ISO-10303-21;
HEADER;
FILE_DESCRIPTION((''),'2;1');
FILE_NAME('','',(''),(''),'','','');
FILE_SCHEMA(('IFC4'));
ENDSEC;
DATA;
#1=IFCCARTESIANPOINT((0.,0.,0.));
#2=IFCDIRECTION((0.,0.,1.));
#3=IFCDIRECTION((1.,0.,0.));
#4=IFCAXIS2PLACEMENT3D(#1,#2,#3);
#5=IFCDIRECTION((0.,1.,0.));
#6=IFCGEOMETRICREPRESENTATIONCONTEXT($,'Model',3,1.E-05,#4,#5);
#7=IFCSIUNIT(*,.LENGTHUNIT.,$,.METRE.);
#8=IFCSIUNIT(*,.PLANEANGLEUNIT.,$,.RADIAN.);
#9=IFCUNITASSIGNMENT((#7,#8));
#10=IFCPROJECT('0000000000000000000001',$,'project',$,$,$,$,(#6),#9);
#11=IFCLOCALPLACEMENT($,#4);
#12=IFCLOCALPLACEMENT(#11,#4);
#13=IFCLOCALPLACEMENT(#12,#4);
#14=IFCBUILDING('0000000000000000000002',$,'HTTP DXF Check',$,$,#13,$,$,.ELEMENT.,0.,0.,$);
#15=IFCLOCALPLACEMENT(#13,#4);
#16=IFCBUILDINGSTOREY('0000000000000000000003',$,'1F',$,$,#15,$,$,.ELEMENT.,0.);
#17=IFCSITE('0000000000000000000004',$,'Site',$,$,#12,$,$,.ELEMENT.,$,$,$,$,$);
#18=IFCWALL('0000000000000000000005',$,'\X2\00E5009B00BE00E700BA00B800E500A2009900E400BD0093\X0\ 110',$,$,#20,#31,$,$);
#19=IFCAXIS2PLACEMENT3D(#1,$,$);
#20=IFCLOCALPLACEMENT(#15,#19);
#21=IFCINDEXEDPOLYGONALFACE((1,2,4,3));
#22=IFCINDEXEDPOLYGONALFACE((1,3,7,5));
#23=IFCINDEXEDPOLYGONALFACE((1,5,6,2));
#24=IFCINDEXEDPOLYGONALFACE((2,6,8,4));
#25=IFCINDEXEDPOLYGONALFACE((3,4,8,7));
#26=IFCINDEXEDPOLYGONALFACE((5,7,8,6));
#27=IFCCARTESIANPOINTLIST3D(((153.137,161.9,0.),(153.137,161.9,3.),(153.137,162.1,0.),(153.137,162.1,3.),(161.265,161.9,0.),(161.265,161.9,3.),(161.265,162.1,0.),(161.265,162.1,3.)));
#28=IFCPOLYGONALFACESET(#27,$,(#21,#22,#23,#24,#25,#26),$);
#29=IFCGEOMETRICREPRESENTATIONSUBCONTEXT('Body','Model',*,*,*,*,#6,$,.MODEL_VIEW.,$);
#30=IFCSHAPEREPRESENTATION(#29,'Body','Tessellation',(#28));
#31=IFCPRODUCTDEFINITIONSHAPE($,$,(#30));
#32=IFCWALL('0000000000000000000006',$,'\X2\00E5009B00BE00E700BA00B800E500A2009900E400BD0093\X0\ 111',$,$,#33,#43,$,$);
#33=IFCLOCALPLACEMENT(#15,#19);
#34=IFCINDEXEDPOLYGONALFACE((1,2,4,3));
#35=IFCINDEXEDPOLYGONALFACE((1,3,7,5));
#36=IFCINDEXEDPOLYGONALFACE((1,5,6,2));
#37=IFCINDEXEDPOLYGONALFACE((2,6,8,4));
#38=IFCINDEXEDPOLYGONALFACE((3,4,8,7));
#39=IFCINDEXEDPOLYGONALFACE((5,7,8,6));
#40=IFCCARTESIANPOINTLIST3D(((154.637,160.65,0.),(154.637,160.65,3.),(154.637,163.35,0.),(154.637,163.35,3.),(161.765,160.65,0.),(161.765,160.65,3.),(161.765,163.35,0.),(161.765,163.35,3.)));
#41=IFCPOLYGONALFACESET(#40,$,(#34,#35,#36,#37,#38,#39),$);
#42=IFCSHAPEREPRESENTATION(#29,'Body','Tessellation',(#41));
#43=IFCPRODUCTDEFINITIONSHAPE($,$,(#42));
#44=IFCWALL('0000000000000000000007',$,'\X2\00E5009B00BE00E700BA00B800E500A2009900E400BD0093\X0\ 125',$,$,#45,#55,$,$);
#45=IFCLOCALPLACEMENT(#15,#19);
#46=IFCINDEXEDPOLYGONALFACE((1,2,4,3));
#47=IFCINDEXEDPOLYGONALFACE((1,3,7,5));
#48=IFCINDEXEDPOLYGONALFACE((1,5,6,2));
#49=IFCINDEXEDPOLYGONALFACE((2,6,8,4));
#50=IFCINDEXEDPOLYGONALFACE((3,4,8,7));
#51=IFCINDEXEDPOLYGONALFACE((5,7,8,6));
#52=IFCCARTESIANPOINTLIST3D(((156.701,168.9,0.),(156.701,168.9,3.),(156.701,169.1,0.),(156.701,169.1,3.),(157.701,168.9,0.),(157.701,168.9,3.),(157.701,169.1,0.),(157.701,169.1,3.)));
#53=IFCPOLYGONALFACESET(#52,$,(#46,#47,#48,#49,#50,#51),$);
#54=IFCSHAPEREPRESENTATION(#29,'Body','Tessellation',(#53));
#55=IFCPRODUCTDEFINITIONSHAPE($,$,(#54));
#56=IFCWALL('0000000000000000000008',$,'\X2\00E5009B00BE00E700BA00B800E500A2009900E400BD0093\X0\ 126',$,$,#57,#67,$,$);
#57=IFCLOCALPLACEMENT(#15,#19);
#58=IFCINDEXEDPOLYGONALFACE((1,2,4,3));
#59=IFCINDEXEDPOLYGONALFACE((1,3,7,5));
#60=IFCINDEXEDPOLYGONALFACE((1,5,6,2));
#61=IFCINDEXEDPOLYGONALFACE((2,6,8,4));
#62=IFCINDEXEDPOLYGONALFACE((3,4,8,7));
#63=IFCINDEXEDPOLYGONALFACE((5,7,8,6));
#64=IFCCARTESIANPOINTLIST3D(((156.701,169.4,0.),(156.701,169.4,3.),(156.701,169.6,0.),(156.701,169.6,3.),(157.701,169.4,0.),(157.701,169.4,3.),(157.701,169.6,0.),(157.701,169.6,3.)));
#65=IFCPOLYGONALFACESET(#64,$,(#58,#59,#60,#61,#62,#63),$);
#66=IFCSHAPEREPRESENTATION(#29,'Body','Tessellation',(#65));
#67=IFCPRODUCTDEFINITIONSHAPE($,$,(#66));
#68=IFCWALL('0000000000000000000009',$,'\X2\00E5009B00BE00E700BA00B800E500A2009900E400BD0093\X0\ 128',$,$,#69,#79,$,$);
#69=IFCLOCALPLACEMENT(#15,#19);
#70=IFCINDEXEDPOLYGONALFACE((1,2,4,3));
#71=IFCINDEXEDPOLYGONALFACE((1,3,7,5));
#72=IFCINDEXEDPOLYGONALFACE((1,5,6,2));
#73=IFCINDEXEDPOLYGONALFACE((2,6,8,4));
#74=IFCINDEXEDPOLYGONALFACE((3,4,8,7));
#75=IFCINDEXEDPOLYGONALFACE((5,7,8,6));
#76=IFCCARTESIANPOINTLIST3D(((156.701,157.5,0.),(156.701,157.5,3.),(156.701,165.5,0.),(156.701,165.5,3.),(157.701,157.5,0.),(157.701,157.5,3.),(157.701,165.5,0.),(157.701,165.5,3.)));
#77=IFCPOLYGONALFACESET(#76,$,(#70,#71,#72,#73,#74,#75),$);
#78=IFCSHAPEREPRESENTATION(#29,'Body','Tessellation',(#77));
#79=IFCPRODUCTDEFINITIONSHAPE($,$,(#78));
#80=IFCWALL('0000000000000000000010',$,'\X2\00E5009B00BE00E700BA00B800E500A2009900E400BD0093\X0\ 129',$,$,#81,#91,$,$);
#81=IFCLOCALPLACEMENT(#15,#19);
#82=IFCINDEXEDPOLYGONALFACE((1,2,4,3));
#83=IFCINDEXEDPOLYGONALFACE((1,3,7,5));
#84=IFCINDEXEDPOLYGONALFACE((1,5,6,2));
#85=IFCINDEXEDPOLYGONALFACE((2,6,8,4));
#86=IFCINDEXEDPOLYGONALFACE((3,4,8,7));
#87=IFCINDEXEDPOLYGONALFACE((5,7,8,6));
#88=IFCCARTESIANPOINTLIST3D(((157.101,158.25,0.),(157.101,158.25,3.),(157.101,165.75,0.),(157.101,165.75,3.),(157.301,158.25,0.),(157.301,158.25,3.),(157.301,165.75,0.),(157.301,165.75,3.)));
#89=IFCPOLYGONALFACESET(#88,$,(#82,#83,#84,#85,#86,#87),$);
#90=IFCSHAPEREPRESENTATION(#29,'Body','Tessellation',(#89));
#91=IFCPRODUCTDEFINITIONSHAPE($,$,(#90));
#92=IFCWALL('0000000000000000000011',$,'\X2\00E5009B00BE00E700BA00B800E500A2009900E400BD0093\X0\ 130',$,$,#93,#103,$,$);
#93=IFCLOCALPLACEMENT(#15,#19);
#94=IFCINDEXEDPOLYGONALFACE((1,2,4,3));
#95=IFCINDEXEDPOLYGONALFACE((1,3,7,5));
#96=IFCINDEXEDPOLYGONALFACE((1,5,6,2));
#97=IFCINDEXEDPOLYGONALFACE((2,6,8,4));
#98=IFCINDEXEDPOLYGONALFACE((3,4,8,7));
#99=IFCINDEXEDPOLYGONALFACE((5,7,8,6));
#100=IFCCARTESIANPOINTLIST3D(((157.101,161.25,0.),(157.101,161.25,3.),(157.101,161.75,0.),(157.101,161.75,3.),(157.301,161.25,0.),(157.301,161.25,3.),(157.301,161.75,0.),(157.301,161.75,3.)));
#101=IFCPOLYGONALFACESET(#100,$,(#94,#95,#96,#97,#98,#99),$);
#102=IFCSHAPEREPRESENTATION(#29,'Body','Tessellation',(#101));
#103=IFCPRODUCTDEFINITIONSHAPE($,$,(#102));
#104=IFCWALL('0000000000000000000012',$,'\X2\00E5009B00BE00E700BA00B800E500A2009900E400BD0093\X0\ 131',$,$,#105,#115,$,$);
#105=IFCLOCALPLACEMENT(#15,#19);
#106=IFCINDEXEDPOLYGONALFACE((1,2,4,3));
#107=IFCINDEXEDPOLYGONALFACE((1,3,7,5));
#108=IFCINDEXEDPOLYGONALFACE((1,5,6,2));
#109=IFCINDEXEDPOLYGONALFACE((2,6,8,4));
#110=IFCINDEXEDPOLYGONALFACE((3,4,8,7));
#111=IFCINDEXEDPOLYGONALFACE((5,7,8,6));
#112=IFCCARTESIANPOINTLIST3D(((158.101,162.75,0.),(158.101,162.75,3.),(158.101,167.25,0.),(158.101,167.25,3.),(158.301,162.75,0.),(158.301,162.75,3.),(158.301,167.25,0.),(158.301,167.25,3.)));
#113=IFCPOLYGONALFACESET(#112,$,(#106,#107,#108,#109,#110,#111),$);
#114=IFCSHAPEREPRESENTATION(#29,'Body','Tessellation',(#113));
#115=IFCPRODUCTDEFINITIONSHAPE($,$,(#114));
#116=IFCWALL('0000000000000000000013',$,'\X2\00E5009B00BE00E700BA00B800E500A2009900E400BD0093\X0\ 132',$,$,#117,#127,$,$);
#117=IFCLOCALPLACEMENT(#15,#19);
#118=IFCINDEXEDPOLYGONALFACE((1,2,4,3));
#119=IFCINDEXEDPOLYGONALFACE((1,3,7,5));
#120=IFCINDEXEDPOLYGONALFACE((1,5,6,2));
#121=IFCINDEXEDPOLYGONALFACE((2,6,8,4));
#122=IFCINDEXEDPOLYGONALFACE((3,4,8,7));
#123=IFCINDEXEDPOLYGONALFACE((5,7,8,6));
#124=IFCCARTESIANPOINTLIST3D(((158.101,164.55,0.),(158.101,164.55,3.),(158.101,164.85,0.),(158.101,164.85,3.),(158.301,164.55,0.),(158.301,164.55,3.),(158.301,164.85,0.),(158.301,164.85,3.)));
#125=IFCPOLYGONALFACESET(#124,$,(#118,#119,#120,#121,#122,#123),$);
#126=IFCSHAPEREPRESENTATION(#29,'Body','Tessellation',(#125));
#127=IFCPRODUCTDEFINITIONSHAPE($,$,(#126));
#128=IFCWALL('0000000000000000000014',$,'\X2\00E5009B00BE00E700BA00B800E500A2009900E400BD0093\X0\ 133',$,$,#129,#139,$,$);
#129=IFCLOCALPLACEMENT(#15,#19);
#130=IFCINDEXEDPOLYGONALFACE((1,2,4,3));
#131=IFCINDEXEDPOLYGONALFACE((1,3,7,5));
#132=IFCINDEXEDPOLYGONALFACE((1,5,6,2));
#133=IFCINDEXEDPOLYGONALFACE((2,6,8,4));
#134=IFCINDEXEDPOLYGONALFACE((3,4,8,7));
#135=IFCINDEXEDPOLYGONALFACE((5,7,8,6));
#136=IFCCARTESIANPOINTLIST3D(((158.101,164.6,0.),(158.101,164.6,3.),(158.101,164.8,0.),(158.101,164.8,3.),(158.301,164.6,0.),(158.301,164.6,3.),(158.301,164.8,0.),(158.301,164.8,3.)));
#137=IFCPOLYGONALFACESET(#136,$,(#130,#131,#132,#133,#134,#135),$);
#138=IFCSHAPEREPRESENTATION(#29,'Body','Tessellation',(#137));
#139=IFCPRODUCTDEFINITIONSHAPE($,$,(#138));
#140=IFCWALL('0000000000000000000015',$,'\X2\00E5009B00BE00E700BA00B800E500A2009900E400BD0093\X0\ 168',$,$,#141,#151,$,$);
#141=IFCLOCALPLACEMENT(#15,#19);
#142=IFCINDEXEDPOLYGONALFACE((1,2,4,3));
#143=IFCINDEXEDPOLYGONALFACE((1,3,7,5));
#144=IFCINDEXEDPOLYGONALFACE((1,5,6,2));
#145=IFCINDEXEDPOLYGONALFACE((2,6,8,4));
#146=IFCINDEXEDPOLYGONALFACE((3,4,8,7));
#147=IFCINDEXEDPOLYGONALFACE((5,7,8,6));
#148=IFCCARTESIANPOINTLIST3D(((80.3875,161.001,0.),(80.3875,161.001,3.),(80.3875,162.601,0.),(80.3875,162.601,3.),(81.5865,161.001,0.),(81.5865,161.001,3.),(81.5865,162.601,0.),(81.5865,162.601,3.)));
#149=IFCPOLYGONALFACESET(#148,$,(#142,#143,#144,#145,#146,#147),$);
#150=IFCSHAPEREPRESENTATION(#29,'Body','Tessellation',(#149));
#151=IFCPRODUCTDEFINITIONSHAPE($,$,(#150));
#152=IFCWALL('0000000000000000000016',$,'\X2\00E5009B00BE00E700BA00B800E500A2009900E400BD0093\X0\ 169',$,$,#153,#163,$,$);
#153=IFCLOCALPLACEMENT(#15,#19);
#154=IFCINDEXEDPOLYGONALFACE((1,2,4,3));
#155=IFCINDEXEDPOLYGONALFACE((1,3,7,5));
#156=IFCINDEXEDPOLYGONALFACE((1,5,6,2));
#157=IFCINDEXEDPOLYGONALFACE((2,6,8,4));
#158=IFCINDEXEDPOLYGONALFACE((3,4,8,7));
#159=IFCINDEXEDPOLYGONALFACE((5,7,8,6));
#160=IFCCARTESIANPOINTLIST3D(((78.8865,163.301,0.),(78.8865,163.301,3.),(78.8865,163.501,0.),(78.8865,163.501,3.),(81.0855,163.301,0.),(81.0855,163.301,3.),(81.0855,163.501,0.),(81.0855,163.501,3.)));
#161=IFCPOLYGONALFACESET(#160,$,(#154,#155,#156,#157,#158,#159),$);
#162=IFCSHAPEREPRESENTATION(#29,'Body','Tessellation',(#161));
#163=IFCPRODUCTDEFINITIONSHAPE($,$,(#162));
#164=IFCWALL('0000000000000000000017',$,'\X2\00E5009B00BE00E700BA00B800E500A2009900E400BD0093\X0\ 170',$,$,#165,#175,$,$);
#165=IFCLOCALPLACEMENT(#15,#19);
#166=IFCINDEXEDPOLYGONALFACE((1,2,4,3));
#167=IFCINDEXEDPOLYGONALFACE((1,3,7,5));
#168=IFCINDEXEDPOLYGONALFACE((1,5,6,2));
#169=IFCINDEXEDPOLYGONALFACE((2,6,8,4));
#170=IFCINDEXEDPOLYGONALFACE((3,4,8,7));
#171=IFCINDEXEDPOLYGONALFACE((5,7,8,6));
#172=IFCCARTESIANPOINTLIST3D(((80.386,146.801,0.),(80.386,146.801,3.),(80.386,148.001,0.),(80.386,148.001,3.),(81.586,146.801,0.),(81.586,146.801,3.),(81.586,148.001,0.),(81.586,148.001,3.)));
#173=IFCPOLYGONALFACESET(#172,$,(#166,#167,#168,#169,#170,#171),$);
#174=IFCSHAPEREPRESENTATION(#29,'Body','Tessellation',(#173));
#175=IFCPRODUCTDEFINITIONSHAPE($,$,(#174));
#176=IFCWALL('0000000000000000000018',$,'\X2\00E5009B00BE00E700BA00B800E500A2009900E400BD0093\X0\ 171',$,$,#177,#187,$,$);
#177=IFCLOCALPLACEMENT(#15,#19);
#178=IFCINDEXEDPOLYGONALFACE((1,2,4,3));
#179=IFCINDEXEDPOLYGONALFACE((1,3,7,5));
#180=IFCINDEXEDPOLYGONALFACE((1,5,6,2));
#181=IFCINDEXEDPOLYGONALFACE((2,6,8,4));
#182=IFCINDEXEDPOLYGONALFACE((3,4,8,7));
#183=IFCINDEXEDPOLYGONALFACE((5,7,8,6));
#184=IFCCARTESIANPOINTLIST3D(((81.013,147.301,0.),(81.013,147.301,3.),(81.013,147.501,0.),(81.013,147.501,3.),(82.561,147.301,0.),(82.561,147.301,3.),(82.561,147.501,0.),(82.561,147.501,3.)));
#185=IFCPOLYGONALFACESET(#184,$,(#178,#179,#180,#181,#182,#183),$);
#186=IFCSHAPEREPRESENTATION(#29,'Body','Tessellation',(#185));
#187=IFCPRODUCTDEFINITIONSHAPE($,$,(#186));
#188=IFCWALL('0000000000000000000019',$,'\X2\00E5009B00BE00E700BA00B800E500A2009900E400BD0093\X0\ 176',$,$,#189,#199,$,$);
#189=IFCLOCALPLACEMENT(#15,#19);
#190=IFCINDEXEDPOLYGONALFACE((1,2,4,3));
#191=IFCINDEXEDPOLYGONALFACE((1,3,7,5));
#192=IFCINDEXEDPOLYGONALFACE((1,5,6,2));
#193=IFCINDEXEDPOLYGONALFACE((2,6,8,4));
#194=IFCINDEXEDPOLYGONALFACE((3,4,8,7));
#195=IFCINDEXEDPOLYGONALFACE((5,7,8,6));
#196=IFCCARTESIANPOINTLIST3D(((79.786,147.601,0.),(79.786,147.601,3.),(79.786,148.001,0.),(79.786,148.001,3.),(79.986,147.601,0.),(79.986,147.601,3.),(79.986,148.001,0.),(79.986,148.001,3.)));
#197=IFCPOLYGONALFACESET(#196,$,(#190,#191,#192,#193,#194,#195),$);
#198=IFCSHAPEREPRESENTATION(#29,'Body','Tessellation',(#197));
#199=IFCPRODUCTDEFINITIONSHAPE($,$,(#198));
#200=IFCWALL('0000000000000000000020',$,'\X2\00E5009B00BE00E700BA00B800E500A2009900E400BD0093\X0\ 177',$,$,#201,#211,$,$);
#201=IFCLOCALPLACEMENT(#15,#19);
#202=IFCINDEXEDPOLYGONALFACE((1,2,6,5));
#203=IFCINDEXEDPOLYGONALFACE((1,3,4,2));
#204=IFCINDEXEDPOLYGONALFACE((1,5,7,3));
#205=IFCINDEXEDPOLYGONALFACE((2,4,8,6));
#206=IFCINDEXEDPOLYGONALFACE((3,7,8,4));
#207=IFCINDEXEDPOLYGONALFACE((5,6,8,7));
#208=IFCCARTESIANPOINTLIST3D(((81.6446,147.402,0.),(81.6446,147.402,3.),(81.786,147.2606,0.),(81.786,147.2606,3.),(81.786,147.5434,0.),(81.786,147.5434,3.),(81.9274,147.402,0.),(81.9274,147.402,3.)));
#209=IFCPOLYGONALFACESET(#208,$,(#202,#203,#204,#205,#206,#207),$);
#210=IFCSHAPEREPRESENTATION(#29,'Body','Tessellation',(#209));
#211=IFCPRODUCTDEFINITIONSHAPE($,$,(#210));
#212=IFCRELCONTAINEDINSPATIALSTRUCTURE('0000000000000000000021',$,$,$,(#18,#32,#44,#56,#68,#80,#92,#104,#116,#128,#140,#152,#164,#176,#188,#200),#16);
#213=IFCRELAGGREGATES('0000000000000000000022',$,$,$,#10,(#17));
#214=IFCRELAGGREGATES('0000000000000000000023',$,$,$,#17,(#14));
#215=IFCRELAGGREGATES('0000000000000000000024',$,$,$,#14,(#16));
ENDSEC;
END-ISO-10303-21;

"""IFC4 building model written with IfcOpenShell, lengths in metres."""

from ifc_helpers import new_model, si_unit, direction, frame, frame_2d, origin_with_axes, place, context, subcontext, project, spatial, rectangle, extrude, element, save


model = new_model("IFC4")

# Units and contexts
model_context = context("Model", 3, precision=1e-05, world=origin_with_axes(), true_north=direction((0.0, 1.0, 0.0)))
body_context = subcontext(model_context, "Body", "Model", "MODEL_VIEW")
ifc_project = project(units=[si_unit("LENGTHUNIT", "METRE"), si_unit("PLANEANGLEUNIT", "RADIAN")], contexts=[model_context])

# Site, building, storey
placement = place(None, origin_with_axes())
site_placement = place(placement, origin_with_axes())
site = spatial("IfcSite", under=ifc_project, at=site_placement, Name="Site", CompositionType="ELEMENT")
building_placement = place(site_placement, origin_with_axes())
building = spatial("IfcBuilding", under=site, at=building_placement, Name="HTTP DXF Check", CompositionType="ELEMENT", ElevationOfRefHeight=0.0, ElevationOfTerrain=0.0)
storey_placement = place(building_placement, origin_with_axes())
storey = spatial("IfcBuildingStorey", under=building, at=storey_placement, Name="1F", CompositionType="ELEMENT", Elevation=0.0)

# Walls
wall_1_placement = place(storey_placement, frame((157.201, 162.0, 0.0), z_axis=(0.0, 0.0, 1.0), x_axis=(1.0, 0.0, 0.0)))
element("IfcWall", 1, at=wall_1_placement, inside=storey, Name="å\u009b¾çº¸å¢\u0099ä½\u0093 110", context=body_context, shape_type="SweptSolid", body=[
    extrude(rectangle(XDim=8.128, YDim=0.2, at=frame_2d((0.0, 0.0), x_axis=(1.0, 0.0, 0.0))), frame((0.0, 0.0, 0.0), z_axis=(0.0, 0.0, 1.0)), (0.0, 0.0, 1.0), 3.0),
])
wall_2_placement = place(storey_placement, frame((158.201, 162.0, 0.0), z_axis=(0.0, 0.0, 1.0), x_axis=(1.0, 0.0, 0.0)))
element("IfcWall", 2, at=wall_2_placement, inside=storey, Name="å\u009b¾çº¸å¢\u0099ä½\u0093 111", context=body_context, shape_type="SweptSolid", body=[
    extrude(rectangle(XDim=7.128, YDim=2.7, at=frame_2d((0.0, 0.0), x_axis=(1.0, 0.0, 0.0))), frame((0.0, 0.0, 0.0), z_axis=(0.0, 0.0, 1.0)), (0.0, 0.0, 1.0), 3.0),
])
for number, where, z_axis, x_axis, name in (
    (3, (157.201, 169.0, 0.0), (0.0, 0.0, 1.0), (1.0, 0.0, 0.0), "å\u009b¾çº¸å¢\u0099ä½\u0093 125"),
    (4, (157.201, 169.5, 0.0), (0.0, 0.0, 1.0), (1.0, 0.0, 0.0), "å\u009b¾çº¸å¢\u0099ä½\u0093 126"),
):
    element("IfcWall", number, at=place(storey_placement, frame(where, z_axis=z_axis, x_axis=x_axis)), inside=storey, Name=name, context=body_context, shape_type="SweptSolid", body=[
        extrude(rectangle(XDim=1.0, YDim=0.2, at=frame_2d((0.0, 0.0), x_axis=(1.0, 0.0, 0.0))), frame((0.0, 0.0, 0.0), z_axis=(0.0, 0.0, 1.0)), (0.0, 0.0, 1.0), 3.0),
    ])
wall_3_placement = place(storey_placement, frame((157.201, 161.5, 0.0), z_axis=(0.0, 0.0, 1.0), x_axis=(1.0, 0.0, 0.0)))
element("IfcWall", 5, at=wall_3_placement, inside=storey, Name="å\u009b¾çº¸å¢\u0099ä½\u0093 128", context=body_context, shape_type="SweptSolid", body=[
    extrude(rectangle(XDim=1.0, YDim=8.0, at=frame_2d((0.0, 0.0), x_axis=(1.0, 0.0, 0.0))), frame((0.0, 0.0, 0.0), z_axis=(0.0, 0.0, 1.0)), (0.0, 0.0, 1.0), 3.0),
])
wall_4_placement = place(storey_placement, frame((157.201, 162.0, 0.0), z_axis=(0.0, 0.0, 1.0), x_axis=(0.0, 1.0, 0.0)))
element("IfcWall", 6, at=wall_4_placement, inside=storey, Name="å\u009b¾çº¸å¢\u0099ä½\u0093 129", context=body_context, shape_type="SweptSolid", body=[
    extrude(rectangle(XDim=7.5, YDim=0.2, at=frame_2d((0.0, 0.0), x_axis=(1.0, 0.0, 0.0))), frame((0.0, 0.0, 0.0), z_axis=(0.0, 0.0, 1.0)), (0.0, 0.0, 1.0), 3.0),
])
wall_5_placement = place(storey_placement, frame((157.201, 161.5, 0.0), z_axis=(0.0, 0.0, 1.0), x_axis=(0.0, 1.0, 0.0)))
element("IfcWall", 7, at=wall_5_placement, inside=storey, Name="å\u009b¾çº¸å¢\u0099ä½\u0093 130", context=body_context, shape_type="SweptSolid", body=[
    extrude(rectangle(XDim=0.5, YDim=0.2, at=frame_2d((0.0, 0.0), x_axis=(1.0, 0.0, 0.0))), frame((0.0, 0.0, 0.0), z_axis=(0.0, 0.0, 1.0)), (0.0, 0.0, 1.0), 3.0),
])
wall_6_placement = place(storey_placement, frame((158.201, 165.0, 0.0), z_axis=(0.0, 0.0, 1.0), x_axis=(0.0, 1.0, 0.0)))
element("IfcWall", 8, at=wall_6_placement, inside=storey, Name="å\u009b¾çº¸å¢\u0099ä½\u0093 131", context=body_context, shape_type="SweptSolid", body=[
    extrude(rectangle(XDim=4.5, YDim=0.2, at=frame_2d((0.0, 0.0), x_axis=(1.0, 0.0, 0.0))), frame((0.0, 0.0, 0.0), z_axis=(0.0, 0.0, 1.0)), (0.0, 0.0, 1.0), 3.0),
])
wall_7_placement = place(storey_placement, frame((158.201, 164.7, 0.0), z_axis=(0.0, 0.0, 1.0), x_axis=(1.0, 0.0, 0.0)))
element("IfcWall", 9, at=wall_7_placement, inside=storey, Name="å\u009b¾çº¸å¢\u0099ä½\u0093 132", context=body_context, shape_type="SweptSolid", body=[
    extrude(rectangle(XDim=0.2, YDim=0.3, at=frame_2d((0.0, 0.0), x_axis=(1.0, 0.0, 0.0))), frame((0.0, 0.0, 0.0), z_axis=(0.0, 0.0, 1.0)), (0.0, 0.0, 1.0), 3.0),
])
wall_8_placement = place(storey_placement, frame((158.201, 164.7, 0.0), z_axis=(0.0, 0.0, 1.0), x_axis=(1.0, 0.0, 0.0)))
element("IfcWall", 10, at=wall_8_placement, inside=storey, Name="å\u009b¾çº¸å¢\u0099ä½\u0093 133", context=body_context, shape_type="SweptSolid", body=[
    extrude(rectangle(XDim=0.2, YDim=0.2, at=frame_2d((0.0, 0.0), x_axis=(1.0, 0.0, 0.0))), frame((0.0, 0.0, 0.0), z_axis=(0.0, 0.0, 1.0)), (0.0, 0.0, 1.0), 3.0),
])
wall_9_placement = place(storey_placement, frame((80.987, 161.801, 0.0), z_axis=(0.0, 0.0, 1.0), x_axis=(1.0, 0.0, 0.0)))
element("IfcWall", 11, at=wall_9_placement, inside=storey, Name="å\u009b¾çº¸å¢\u0099ä½\u0093 168", context=body_context, shape_type="SweptSolid", body=[
    extrude(rectangle(XDim=1.199, YDim=1.6, at=frame_2d((0.0, 0.0), x_axis=(1.0, 0.0, 0.0))), frame((0.0, 0.0, 0.0), z_axis=(0.0, 0.0, 1.0)), (0.0, 0.0, 1.0), 3.0),
])
wall_10_placement = place(storey_placement, frame((79.986, 163.401, 0.0), z_axis=(0.0, 0.0, 1.0), x_axis=(1.0, 0.0, 0.0)))
element("IfcWall", 12, at=wall_10_placement, inside=storey, Name="å\u009b¾çº¸å¢\u0099ä½\u0093 169", context=body_context, shape_type="SweptSolid", body=[
    extrude(rectangle(XDim=2.199, YDim=0.2, at=frame_2d((0.0, 0.0), x_axis=(1.0, 0.0, 0.0))), frame((0.0, 0.0, 0.0), z_axis=(0.0, 0.0, 1.0)), (0.0, 0.0, 1.0), 3.0),
])
wall_11_placement = place(storey_placement, frame((80.986, 147.401, 0.0), z_axis=(0.0, 0.0, 1.0), x_axis=(1.0, 0.0, 0.0)))
element("IfcWall", 13, at=wall_11_placement, inside=storey, Name="å\u009b¾çº¸å¢\u0099ä½\u0093 170", context=body_context, shape_type="SweptSolid", body=[
    extrude(rectangle(XDim=1.2, YDim=1.2, at=frame_2d((0.0, 0.0), x_axis=(1.0, 0.0, 0.0))), frame((0.0, 0.0, 0.0), z_axis=(0.0, 0.0, 1.0)), (0.0, 0.0, 1.0), 3.0),
])
wall_12_placement = place(storey_placement, frame((81.787, 147.401, 0.0), z_axis=(0.0, 0.0, 1.0), x_axis=(1.0, 0.0, 0.0)))
element("IfcWall", 14, at=wall_12_placement, inside=storey, Name="å\u009b¾çº¸å¢\u0099ä½\u0093 171", context=body_context, shape_type="SweptSolid", body=[
    extrude(rectangle(XDim=1.548, YDim=0.2, at=frame_2d((0.0, 0.0), x_axis=(1.0, 0.0, 0.0))), frame((0.0, 0.0, 0.0), z_axis=(0.0, 0.0, 1.0)), (0.0, 0.0, 1.0), 3.0),
])
wall_13_placement = place(storey_placement, frame((79.886, 147.801, 0.0), z_axis=(0.0, 0.0, 1.0), x_axis=(0.0, -1.0, 0.0)))
element("IfcWall", 15, at=wall_13_placement, inside=storey, Name="å\u009b¾çº¸å¢\u0099ä½\u0093 176", context=body_context, shape_type="SweptSolid", body=[
    extrude(rectangle(XDim=0.4, YDim=0.2, at=frame_2d((0.0, 0.0), x_axis=(1.0, 0.0, 0.0))), frame((0.0, 0.0, 0.0), z_axis=(0.0, 0.0, 1.0)), (0.0, 0.0, 1.0), 3.0),
])
wall_14_placement = place(storey_placement, frame((81.786, 147.402, 0.0), z_axis=(0.0, 0.0, 1.0), x_axis=(0.707107, -0.707107, 0.0)))
element("IfcWall", 16, at=wall_14_placement, inside=storey, Name="å\u009b¾çº¸å¢\u0099ä½\u0093 177", context=body_context, shape_type="SweptSolid", body=[
    extrude(rectangle(XDim=0.2, YDim=0.2, at=frame_2d((0.0, 0.0), x_axis=(1.0, 0.0, 0.0))), frame((0.0, 0.0, 0.0), z_axis=(0.0, 0.0, 1.0)), (0.0, 0.0, 1.0), 3.0),
])

save(model, "model.ifc")
